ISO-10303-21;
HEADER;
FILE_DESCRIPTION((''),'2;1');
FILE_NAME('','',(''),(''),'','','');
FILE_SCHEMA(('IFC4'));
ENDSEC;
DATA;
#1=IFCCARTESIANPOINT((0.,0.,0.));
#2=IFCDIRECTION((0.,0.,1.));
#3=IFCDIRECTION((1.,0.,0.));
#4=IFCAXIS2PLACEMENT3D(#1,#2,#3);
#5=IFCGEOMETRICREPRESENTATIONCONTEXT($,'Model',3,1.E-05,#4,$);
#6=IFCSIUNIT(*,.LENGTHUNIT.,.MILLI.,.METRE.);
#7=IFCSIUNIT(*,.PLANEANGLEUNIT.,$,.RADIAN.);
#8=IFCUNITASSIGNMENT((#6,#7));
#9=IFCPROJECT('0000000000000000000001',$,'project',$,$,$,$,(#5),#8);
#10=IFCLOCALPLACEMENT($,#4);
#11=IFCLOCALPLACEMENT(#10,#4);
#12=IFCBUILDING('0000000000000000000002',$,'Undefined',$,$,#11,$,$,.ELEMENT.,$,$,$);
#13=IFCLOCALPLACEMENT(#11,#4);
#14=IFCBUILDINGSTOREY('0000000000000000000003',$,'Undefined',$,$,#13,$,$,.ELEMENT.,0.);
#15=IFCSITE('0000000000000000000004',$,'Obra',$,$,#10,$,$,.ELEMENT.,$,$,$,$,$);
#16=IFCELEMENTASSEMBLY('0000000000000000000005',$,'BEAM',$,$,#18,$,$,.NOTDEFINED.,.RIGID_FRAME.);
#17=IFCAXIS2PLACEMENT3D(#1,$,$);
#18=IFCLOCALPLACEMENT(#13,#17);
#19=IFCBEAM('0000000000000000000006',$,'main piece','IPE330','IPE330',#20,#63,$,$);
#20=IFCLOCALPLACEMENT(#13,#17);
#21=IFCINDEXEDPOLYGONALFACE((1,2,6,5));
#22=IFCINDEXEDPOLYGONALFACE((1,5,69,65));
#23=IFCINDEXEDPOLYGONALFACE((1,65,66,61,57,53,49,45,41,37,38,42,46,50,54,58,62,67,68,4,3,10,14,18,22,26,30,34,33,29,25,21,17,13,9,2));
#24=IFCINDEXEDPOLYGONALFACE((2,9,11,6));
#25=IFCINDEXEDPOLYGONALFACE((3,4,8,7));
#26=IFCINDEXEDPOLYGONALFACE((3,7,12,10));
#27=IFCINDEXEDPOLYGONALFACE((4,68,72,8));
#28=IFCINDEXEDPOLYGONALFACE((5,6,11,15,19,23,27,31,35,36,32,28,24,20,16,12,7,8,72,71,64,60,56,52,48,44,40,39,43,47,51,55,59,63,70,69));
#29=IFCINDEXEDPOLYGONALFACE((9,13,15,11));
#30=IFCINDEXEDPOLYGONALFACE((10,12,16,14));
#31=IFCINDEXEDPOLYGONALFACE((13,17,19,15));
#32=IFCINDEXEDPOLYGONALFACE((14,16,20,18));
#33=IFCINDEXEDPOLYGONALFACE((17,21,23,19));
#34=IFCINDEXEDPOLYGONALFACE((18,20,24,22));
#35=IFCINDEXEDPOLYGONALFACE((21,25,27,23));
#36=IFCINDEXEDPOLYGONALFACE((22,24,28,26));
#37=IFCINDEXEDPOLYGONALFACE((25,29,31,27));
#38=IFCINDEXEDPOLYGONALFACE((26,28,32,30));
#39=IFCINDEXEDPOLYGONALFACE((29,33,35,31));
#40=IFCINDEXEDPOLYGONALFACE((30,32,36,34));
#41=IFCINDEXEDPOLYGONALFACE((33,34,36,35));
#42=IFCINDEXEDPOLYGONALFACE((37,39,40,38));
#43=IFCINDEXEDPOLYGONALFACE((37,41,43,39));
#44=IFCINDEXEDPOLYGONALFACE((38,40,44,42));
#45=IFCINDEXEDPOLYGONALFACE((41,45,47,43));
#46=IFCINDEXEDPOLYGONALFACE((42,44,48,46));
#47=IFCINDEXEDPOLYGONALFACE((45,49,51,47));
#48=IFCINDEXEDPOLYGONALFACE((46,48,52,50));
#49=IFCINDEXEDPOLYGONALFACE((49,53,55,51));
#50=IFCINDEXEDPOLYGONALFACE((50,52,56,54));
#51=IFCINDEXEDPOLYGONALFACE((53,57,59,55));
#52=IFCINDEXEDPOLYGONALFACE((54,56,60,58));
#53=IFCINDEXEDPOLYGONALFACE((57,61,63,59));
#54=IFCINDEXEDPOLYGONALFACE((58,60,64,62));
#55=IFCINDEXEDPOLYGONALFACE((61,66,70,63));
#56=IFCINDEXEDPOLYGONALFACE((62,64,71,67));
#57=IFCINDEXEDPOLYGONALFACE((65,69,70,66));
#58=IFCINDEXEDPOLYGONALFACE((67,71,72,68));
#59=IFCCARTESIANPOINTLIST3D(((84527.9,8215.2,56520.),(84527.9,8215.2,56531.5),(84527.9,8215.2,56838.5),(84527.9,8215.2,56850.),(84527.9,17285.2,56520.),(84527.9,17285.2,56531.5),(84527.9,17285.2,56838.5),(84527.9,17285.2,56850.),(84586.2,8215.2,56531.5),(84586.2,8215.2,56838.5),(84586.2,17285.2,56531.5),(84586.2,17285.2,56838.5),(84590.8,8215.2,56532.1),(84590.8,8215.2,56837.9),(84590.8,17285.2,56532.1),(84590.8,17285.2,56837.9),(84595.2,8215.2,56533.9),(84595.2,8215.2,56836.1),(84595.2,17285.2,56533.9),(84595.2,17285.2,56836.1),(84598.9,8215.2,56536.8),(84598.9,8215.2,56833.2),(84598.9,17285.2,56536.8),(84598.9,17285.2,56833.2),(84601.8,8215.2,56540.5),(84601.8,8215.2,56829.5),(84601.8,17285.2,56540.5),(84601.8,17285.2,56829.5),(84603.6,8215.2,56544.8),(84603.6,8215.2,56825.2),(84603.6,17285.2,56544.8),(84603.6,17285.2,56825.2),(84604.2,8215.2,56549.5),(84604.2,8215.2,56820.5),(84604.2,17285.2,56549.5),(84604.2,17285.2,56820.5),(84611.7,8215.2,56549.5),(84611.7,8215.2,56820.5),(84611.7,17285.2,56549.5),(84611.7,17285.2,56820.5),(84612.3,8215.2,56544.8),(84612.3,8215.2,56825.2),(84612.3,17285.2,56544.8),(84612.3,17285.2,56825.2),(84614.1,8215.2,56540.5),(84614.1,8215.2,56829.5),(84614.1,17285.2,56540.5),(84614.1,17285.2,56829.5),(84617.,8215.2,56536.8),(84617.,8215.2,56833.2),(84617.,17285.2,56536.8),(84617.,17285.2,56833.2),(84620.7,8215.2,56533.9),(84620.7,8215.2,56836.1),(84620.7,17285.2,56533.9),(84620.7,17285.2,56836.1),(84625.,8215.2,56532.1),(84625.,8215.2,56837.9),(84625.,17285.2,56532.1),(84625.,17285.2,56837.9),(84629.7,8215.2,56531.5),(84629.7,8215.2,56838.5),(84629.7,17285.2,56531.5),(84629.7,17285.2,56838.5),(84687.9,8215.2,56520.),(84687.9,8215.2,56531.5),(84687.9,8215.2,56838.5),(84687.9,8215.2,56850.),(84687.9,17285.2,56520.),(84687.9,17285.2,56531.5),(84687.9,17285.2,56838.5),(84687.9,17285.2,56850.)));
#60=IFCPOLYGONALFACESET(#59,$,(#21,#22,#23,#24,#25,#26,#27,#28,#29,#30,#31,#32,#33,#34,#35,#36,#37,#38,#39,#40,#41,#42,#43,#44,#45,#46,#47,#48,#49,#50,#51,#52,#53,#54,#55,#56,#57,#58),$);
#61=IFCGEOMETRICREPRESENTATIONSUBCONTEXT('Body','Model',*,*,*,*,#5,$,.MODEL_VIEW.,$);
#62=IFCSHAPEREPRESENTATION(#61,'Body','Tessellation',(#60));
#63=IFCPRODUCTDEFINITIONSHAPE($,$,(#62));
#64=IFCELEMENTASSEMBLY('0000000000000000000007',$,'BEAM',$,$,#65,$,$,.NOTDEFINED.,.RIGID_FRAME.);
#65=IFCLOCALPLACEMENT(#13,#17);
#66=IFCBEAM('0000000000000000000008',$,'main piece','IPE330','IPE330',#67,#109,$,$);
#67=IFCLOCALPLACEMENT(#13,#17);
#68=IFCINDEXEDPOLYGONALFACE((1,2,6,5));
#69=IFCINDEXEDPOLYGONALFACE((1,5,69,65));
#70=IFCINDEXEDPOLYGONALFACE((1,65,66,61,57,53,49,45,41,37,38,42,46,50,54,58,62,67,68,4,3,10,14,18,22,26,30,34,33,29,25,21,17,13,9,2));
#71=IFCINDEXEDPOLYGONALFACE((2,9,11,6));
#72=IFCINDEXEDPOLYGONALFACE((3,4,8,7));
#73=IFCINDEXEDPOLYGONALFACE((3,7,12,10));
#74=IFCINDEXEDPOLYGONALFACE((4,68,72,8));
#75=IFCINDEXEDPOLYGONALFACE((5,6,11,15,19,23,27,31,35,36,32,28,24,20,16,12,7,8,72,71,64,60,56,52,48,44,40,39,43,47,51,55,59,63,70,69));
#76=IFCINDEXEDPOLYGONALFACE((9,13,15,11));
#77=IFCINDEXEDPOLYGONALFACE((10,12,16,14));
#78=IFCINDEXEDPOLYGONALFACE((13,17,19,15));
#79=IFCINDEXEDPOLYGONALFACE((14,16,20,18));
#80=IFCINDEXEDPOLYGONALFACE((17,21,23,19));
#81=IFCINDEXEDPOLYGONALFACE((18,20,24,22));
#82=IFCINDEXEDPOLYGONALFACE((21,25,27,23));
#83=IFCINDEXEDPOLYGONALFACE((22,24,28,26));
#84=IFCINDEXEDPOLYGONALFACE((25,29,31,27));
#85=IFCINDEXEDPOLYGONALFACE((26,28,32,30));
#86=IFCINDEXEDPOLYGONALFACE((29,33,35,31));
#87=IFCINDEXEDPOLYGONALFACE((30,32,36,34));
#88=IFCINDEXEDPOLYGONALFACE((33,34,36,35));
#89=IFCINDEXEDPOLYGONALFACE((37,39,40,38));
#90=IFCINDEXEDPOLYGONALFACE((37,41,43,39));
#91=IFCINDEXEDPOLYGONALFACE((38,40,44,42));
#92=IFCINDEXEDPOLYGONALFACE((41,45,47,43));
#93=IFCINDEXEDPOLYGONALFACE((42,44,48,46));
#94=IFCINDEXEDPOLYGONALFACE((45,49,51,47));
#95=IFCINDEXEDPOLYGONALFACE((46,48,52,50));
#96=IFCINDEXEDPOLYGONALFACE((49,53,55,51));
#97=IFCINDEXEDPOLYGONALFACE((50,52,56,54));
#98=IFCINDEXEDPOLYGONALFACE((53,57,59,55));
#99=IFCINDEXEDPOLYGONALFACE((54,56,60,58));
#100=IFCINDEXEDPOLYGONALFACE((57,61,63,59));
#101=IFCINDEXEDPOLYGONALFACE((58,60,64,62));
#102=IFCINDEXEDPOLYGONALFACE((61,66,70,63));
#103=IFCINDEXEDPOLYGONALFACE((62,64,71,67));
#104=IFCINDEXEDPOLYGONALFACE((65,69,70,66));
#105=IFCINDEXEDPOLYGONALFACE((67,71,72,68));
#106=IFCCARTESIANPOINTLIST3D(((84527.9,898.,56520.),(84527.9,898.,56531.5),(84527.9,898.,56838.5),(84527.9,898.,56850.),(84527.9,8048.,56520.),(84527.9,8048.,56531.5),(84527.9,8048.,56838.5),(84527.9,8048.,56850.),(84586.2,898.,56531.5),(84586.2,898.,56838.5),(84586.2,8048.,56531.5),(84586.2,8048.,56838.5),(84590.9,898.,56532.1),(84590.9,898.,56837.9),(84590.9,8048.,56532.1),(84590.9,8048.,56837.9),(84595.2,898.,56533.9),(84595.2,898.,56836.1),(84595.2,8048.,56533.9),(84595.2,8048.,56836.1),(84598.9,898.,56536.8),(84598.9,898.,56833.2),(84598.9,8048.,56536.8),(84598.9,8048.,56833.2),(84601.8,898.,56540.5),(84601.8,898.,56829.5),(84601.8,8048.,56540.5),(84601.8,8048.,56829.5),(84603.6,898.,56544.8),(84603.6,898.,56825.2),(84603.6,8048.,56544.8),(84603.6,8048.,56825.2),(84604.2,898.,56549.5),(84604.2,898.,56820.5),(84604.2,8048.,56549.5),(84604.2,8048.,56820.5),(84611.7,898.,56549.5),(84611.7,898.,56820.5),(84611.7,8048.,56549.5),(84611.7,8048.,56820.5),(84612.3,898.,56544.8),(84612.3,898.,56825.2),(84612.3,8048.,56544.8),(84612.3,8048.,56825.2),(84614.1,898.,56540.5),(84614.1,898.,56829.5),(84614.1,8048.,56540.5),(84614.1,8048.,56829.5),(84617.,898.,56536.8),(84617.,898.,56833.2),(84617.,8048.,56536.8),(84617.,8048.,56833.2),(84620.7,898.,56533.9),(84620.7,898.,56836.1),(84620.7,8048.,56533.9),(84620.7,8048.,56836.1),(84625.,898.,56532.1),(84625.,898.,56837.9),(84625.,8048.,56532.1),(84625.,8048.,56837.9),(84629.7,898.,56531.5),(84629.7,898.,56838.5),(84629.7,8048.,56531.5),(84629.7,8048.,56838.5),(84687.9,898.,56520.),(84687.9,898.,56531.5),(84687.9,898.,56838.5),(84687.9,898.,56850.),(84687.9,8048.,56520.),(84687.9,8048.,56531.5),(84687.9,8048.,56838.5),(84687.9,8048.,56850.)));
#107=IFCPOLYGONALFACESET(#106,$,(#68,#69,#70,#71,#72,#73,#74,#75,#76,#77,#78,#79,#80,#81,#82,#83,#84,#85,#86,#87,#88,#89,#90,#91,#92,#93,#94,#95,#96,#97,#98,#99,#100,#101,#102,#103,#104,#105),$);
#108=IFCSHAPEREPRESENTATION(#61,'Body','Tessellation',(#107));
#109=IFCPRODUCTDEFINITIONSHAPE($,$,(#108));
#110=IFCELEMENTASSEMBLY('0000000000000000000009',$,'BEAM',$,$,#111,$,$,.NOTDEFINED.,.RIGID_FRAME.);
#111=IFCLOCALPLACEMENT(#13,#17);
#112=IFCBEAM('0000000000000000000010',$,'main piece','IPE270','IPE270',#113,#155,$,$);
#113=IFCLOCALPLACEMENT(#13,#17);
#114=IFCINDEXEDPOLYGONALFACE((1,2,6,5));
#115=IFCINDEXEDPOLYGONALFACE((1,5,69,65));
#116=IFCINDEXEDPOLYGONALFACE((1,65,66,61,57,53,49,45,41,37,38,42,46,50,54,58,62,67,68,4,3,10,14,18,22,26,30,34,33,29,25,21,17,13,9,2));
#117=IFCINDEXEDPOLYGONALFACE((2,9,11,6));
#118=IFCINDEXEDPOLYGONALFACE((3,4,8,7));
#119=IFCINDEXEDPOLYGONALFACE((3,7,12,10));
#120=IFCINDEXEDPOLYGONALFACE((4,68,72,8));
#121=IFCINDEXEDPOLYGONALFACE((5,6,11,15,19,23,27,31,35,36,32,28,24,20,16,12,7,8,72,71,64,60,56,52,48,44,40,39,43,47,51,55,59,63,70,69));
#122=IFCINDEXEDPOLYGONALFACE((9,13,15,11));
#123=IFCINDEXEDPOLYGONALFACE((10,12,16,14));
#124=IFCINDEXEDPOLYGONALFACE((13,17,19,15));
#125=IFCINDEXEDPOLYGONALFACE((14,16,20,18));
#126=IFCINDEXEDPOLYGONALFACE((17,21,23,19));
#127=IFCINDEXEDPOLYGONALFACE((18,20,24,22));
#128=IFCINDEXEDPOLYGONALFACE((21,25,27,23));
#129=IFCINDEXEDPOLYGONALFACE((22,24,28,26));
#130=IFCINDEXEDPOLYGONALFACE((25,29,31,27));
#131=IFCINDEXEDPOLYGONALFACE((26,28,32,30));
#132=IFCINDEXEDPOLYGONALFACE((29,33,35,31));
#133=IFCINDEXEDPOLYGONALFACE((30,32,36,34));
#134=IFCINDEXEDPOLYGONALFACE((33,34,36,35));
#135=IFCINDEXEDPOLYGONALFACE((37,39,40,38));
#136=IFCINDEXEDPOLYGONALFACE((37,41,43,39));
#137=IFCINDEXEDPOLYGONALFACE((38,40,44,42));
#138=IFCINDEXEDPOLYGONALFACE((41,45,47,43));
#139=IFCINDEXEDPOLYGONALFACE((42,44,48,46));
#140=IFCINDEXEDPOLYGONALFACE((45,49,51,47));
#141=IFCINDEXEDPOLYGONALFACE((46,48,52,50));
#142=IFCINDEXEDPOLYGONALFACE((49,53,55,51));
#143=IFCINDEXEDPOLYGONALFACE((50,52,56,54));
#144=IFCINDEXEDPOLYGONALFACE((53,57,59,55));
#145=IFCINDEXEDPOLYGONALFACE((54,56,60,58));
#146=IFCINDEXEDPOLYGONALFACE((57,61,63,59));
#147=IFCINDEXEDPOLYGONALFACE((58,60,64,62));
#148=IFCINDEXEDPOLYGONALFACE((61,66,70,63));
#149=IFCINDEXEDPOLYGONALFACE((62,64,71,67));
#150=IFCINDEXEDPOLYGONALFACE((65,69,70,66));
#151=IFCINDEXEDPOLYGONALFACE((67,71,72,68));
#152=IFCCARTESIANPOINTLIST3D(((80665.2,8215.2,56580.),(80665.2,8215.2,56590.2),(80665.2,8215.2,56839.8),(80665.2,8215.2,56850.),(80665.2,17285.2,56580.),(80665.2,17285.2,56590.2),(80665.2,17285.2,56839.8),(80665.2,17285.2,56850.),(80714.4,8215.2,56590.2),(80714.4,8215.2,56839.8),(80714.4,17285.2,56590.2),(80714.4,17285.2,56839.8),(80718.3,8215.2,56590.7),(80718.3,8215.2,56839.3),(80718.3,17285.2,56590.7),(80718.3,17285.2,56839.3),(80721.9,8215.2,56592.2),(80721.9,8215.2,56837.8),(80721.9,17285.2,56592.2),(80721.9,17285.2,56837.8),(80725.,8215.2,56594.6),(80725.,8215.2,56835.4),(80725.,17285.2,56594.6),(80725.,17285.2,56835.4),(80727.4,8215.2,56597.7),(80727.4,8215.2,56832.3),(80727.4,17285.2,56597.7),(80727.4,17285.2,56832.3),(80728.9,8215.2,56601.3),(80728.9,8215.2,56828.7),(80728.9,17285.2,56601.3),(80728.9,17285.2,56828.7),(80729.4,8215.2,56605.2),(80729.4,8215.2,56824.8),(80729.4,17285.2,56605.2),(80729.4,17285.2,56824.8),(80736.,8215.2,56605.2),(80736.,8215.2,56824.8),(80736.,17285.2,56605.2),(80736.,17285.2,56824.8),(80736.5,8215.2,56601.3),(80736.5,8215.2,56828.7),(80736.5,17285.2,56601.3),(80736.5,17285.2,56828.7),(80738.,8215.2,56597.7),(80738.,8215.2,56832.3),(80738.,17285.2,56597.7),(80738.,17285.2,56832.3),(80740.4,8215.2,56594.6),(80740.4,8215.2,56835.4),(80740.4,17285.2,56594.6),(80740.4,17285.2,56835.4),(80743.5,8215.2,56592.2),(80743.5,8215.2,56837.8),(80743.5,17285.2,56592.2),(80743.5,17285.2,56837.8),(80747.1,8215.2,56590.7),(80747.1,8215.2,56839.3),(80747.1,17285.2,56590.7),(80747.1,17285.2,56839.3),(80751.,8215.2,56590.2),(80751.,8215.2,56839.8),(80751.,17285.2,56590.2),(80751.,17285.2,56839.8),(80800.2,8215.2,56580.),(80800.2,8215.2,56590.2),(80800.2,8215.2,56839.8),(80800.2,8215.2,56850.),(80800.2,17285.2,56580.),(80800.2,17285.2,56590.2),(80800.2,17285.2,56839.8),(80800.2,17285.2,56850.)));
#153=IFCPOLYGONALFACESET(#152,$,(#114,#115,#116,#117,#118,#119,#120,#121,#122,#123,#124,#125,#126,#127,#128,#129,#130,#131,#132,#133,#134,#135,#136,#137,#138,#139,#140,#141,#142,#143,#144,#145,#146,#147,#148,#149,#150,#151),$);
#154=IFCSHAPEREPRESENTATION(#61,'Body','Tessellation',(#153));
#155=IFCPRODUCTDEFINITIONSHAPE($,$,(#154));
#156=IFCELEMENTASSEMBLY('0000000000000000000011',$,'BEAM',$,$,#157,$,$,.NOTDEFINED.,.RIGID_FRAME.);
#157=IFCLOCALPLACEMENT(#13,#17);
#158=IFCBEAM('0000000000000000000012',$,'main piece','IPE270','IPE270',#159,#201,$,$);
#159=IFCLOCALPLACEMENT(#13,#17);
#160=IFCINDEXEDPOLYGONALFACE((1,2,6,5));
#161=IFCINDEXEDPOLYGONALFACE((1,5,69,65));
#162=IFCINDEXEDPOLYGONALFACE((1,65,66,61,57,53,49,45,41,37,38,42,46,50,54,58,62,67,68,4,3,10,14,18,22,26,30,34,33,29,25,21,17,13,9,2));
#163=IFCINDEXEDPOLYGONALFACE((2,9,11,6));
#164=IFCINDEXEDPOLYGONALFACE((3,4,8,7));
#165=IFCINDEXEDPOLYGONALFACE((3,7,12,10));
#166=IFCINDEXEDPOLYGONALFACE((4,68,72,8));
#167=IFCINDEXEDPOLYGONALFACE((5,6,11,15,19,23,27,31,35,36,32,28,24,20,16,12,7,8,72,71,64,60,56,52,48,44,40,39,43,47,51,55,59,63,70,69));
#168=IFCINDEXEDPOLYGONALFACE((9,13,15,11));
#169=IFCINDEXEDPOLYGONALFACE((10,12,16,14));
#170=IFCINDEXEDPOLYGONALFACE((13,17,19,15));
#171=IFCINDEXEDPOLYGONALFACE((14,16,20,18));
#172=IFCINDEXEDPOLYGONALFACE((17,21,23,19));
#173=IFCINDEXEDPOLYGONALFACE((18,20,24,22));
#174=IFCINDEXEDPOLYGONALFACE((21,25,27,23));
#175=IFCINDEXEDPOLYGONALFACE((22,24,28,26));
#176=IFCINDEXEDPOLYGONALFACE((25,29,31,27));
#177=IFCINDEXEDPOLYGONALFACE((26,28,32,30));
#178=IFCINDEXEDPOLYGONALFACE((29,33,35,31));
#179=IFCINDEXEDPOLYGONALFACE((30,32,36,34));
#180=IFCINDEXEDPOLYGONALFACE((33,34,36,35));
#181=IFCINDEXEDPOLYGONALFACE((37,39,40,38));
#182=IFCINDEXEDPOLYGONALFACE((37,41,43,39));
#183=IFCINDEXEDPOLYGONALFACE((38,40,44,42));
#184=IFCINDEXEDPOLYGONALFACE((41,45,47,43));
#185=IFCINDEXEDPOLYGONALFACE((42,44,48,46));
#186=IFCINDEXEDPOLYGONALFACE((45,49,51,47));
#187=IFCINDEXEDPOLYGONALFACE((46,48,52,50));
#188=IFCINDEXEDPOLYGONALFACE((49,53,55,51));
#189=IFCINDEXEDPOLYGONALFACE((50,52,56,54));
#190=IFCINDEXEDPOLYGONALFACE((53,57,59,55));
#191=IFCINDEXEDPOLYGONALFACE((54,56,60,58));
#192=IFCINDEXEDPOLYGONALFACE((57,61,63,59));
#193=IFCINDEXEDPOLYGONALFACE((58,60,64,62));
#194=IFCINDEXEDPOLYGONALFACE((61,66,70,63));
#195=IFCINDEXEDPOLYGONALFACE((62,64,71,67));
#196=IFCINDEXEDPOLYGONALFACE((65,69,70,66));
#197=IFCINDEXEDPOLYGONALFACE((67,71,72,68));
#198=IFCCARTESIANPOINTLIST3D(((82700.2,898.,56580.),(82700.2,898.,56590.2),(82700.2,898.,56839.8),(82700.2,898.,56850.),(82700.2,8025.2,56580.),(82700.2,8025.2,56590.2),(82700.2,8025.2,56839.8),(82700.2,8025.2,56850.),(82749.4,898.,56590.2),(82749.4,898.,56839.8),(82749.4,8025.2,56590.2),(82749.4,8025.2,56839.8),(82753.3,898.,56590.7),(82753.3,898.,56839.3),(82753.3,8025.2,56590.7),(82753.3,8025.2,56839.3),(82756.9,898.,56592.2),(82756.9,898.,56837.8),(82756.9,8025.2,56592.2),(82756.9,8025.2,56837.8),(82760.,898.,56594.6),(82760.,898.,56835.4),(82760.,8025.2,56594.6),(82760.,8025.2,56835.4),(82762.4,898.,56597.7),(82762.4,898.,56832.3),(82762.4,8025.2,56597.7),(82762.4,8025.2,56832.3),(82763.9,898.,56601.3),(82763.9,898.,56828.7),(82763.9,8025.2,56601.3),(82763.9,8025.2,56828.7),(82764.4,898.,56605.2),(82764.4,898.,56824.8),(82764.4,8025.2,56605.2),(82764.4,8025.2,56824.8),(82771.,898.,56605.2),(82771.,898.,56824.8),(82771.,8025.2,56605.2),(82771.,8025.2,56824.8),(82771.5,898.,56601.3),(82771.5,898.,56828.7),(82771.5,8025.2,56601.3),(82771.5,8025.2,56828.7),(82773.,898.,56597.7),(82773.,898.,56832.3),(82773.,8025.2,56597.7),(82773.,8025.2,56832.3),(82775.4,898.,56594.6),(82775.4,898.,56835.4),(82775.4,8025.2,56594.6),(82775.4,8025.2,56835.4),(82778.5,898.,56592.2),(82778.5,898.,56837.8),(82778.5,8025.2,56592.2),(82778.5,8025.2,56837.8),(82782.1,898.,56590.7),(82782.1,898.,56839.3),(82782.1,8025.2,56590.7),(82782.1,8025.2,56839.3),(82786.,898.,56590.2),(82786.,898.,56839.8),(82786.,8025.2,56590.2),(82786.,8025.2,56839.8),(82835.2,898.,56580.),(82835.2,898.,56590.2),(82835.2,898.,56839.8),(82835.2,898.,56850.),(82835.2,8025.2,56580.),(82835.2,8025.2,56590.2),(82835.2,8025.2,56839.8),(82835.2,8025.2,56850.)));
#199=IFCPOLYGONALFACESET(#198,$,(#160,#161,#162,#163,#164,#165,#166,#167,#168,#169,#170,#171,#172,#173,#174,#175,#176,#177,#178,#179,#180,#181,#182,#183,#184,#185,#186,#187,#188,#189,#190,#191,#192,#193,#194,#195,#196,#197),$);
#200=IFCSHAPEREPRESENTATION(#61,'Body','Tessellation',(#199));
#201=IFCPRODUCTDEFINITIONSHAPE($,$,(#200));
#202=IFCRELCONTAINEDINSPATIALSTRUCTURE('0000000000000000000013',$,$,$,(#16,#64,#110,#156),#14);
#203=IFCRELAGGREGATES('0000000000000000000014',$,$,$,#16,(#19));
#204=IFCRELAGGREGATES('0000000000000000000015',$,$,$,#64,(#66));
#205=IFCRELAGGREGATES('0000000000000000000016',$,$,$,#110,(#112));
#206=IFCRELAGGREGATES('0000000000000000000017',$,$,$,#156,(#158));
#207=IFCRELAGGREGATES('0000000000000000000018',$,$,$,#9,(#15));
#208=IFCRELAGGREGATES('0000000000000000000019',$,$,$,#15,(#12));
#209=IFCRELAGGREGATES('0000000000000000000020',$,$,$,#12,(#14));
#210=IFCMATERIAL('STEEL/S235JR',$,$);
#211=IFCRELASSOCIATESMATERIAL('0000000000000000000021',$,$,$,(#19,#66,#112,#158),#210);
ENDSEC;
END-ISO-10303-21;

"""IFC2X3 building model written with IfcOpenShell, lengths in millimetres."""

from ifc_helpers import new_model, si_unit, frame, origin_with_axes, origin_2d_with_axis, place, context, subcontext, project, spatial, i_section, extrude, material, element, aggregate, save


model = new_model("IFC2X3")

# Units and contexts
model_context = context("Model", 3, precision=1e-05, world=origin_with_axes())
body_context = subcontext(model_context, "Body", "Model", "MODEL_VIEW")
ifc_project = project(units=[si_unit("LENGTHUNIT", "METRE", prefix="MILLI"), si_unit("PLANEANGLEUNIT", "RADIAN")], contexts=[model_context])

# Site, building, storey
site_placement = place(None, origin_with_axes())
site = spatial("IfcSite", under=ifc_project, at=site_placement, Name="Obra", CompositionType="ELEMENT")
building_placement = place(site_placement, origin_with_axes())
building = spatial("IfcBuilding", under=site, at=building_placement, Name="Undefined", CompositionType="ELEMENT")
storey_placement = place(building_placement, origin_with_axes())
storey = spatial("IfcBuildingStorey", under=building, at=storey_placement, Name="Undefined", CompositionType="ELEMENT", Elevation=0.0)

# Shared definitions
ifc_material_1 = material(Name="STEEL/S235JR")

# Element assemblies, beams
assembly_1_placement = place(storey_placement, origin_with_axes())
assembly_1 = element("IfcElementAssembly", 1, at=assembly_1_placement, inside=storey, Name="BEAM", AssemblyPlace="NOTDEFINED", PredefinedType="RIGID_FRAME")
beam_1_placement = place(assembly_1_placement, frame((84607.9, 8215.2, 56685.0), z_axis=(0.0, 0.0, 1.0), x_axis=(0.0, 1.0, 0.0)))
beam_1 = element("IfcBeam", 2, at=beam_1_placement, material=ifc_material_1, Name="main piece", Description="IPE330", ObjectType="IPE330", context=body_context, shape_type="SweptSolid", body=[
    extrude(i_section(OverallWidth=160.0, OverallDepth=330.0, WebThickness=7.5, FlangeThickness=11.5, FilletRadius=18.0, at=origin_2d_with_axis()), frame((9070.0, 0.0, 0.0), z_axis=(-1.0, 0.0, 0.0), x_axis=(0.0, -1.0, 0.0)), (0.0, 0.0, 1.0), 9070.0),
])
aggregate(assembly_1, [beam_1])
assembly_2_placement = place(storey_placement, origin_with_axes())
assembly_2 = element("IfcElementAssembly", 3, at=assembly_2_placement, inside=storey, Name="BEAM", AssemblyPlace="NOTDEFINED", PredefinedType="RIGID_FRAME")
beam_2_placement = place(assembly_2_placement, frame((84607.9, 898.0, 56685.0), z_axis=(0.0, 0.0, 1.0), x_axis=(0.0, 1.0, 0.0)))
beam_2 = element("IfcBeam", 4, at=beam_2_placement, material=ifc_material_1, Name="main piece", Description="IPE330", ObjectType="IPE330", context=body_context, shape_type="SweptSolid", body=[
    extrude(i_section(OverallWidth=160.0, OverallDepth=330.0, WebThickness=7.5, FlangeThickness=11.5, FilletRadius=18.0, at=origin_2d_with_axis()), frame((7150.0, 0.0, 0.0), z_axis=(-1.0, 0.0, 0.0), x_axis=(0.0, -1.0, 0.0)), (0.0, 0.0, 1.0), 7150.0),
])
aggregate(assembly_2, [beam_2])
assembly_3_placement = place(storey_placement, origin_with_axes())
assembly_3 = element("IfcElementAssembly", 5, at=assembly_3_placement, inside=storey, Name="BEAM", AssemblyPlace="NOTDEFINED", PredefinedType="RIGID_FRAME")
beam_3_placement = place(assembly_3_placement, frame((80732.7, 8215.2, 56715.0), z_axis=(0.0, 0.0, 1.0), x_axis=(0.0, 1.0, 0.0)))
beam_3 = element("IfcBeam", 6, at=beam_3_placement, material=ifc_material_1, Name="main piece", Description="IPE270", ObjectType="IPE270", context=body_context, shape_type="SweptSolid", body=[
    extrude(i_section(OverallWidth=135.0, OverallDepth=270.0, WebThickness=6.6, FlangeThickness=10.2, FilletRadius=15.0, at=origin_2d_with_axis()), frame((9070.0, 0.0, 0.0), z_axis=(-1.0, 0.0, 0.0), x_axis=(0.0, -1.0, 0.0)), (0.0, 0.0, 1.0), 9070.0),
])
aggregate(assembly_3, [beam_3])
assembly_4_placement = place(storey_placement, origin_with_axes())
assembly_4 = element("IfcElementAssembly", 7, at=assembly_4_placement, inside=storey, Name="BEAM", AssemblyPlace="NOTDEFINED", PredefinedType="RIGID_FRAME")
beam_4_placement = place(assembly_4_placement, frame((82767.7, 898.0, 56715.0), z_axis=(0.0, 0.0, 1.0), x_axis=(0.0, 1.0, 0.0)))
beam_4 = element("IfcBeam", 8, at=beam_4_placement, material=ifc_material_1, Name="main piece", Description="IPE270", ObjectType="IPE270", context=body_context, shape_type="SweptSolid", body=[
    extrude(i_section(OverallWidth=135.0, OverallDepth=270.0, WebThickness=6.6, FlangeThickness=10.2, FilletRadius=15.0, at=origin_2d_with_axis()), frame((7127.2, 0.0, 0.0), z_axis=(-1.0, 0.0, 0.0), x_axis=(0.0, -1.0, 0.0)), (0.0, 0.0, 1.0), 7127.2),
])
aggregate(assembly_4, [beam_4])

save(model, "model.ifc")
